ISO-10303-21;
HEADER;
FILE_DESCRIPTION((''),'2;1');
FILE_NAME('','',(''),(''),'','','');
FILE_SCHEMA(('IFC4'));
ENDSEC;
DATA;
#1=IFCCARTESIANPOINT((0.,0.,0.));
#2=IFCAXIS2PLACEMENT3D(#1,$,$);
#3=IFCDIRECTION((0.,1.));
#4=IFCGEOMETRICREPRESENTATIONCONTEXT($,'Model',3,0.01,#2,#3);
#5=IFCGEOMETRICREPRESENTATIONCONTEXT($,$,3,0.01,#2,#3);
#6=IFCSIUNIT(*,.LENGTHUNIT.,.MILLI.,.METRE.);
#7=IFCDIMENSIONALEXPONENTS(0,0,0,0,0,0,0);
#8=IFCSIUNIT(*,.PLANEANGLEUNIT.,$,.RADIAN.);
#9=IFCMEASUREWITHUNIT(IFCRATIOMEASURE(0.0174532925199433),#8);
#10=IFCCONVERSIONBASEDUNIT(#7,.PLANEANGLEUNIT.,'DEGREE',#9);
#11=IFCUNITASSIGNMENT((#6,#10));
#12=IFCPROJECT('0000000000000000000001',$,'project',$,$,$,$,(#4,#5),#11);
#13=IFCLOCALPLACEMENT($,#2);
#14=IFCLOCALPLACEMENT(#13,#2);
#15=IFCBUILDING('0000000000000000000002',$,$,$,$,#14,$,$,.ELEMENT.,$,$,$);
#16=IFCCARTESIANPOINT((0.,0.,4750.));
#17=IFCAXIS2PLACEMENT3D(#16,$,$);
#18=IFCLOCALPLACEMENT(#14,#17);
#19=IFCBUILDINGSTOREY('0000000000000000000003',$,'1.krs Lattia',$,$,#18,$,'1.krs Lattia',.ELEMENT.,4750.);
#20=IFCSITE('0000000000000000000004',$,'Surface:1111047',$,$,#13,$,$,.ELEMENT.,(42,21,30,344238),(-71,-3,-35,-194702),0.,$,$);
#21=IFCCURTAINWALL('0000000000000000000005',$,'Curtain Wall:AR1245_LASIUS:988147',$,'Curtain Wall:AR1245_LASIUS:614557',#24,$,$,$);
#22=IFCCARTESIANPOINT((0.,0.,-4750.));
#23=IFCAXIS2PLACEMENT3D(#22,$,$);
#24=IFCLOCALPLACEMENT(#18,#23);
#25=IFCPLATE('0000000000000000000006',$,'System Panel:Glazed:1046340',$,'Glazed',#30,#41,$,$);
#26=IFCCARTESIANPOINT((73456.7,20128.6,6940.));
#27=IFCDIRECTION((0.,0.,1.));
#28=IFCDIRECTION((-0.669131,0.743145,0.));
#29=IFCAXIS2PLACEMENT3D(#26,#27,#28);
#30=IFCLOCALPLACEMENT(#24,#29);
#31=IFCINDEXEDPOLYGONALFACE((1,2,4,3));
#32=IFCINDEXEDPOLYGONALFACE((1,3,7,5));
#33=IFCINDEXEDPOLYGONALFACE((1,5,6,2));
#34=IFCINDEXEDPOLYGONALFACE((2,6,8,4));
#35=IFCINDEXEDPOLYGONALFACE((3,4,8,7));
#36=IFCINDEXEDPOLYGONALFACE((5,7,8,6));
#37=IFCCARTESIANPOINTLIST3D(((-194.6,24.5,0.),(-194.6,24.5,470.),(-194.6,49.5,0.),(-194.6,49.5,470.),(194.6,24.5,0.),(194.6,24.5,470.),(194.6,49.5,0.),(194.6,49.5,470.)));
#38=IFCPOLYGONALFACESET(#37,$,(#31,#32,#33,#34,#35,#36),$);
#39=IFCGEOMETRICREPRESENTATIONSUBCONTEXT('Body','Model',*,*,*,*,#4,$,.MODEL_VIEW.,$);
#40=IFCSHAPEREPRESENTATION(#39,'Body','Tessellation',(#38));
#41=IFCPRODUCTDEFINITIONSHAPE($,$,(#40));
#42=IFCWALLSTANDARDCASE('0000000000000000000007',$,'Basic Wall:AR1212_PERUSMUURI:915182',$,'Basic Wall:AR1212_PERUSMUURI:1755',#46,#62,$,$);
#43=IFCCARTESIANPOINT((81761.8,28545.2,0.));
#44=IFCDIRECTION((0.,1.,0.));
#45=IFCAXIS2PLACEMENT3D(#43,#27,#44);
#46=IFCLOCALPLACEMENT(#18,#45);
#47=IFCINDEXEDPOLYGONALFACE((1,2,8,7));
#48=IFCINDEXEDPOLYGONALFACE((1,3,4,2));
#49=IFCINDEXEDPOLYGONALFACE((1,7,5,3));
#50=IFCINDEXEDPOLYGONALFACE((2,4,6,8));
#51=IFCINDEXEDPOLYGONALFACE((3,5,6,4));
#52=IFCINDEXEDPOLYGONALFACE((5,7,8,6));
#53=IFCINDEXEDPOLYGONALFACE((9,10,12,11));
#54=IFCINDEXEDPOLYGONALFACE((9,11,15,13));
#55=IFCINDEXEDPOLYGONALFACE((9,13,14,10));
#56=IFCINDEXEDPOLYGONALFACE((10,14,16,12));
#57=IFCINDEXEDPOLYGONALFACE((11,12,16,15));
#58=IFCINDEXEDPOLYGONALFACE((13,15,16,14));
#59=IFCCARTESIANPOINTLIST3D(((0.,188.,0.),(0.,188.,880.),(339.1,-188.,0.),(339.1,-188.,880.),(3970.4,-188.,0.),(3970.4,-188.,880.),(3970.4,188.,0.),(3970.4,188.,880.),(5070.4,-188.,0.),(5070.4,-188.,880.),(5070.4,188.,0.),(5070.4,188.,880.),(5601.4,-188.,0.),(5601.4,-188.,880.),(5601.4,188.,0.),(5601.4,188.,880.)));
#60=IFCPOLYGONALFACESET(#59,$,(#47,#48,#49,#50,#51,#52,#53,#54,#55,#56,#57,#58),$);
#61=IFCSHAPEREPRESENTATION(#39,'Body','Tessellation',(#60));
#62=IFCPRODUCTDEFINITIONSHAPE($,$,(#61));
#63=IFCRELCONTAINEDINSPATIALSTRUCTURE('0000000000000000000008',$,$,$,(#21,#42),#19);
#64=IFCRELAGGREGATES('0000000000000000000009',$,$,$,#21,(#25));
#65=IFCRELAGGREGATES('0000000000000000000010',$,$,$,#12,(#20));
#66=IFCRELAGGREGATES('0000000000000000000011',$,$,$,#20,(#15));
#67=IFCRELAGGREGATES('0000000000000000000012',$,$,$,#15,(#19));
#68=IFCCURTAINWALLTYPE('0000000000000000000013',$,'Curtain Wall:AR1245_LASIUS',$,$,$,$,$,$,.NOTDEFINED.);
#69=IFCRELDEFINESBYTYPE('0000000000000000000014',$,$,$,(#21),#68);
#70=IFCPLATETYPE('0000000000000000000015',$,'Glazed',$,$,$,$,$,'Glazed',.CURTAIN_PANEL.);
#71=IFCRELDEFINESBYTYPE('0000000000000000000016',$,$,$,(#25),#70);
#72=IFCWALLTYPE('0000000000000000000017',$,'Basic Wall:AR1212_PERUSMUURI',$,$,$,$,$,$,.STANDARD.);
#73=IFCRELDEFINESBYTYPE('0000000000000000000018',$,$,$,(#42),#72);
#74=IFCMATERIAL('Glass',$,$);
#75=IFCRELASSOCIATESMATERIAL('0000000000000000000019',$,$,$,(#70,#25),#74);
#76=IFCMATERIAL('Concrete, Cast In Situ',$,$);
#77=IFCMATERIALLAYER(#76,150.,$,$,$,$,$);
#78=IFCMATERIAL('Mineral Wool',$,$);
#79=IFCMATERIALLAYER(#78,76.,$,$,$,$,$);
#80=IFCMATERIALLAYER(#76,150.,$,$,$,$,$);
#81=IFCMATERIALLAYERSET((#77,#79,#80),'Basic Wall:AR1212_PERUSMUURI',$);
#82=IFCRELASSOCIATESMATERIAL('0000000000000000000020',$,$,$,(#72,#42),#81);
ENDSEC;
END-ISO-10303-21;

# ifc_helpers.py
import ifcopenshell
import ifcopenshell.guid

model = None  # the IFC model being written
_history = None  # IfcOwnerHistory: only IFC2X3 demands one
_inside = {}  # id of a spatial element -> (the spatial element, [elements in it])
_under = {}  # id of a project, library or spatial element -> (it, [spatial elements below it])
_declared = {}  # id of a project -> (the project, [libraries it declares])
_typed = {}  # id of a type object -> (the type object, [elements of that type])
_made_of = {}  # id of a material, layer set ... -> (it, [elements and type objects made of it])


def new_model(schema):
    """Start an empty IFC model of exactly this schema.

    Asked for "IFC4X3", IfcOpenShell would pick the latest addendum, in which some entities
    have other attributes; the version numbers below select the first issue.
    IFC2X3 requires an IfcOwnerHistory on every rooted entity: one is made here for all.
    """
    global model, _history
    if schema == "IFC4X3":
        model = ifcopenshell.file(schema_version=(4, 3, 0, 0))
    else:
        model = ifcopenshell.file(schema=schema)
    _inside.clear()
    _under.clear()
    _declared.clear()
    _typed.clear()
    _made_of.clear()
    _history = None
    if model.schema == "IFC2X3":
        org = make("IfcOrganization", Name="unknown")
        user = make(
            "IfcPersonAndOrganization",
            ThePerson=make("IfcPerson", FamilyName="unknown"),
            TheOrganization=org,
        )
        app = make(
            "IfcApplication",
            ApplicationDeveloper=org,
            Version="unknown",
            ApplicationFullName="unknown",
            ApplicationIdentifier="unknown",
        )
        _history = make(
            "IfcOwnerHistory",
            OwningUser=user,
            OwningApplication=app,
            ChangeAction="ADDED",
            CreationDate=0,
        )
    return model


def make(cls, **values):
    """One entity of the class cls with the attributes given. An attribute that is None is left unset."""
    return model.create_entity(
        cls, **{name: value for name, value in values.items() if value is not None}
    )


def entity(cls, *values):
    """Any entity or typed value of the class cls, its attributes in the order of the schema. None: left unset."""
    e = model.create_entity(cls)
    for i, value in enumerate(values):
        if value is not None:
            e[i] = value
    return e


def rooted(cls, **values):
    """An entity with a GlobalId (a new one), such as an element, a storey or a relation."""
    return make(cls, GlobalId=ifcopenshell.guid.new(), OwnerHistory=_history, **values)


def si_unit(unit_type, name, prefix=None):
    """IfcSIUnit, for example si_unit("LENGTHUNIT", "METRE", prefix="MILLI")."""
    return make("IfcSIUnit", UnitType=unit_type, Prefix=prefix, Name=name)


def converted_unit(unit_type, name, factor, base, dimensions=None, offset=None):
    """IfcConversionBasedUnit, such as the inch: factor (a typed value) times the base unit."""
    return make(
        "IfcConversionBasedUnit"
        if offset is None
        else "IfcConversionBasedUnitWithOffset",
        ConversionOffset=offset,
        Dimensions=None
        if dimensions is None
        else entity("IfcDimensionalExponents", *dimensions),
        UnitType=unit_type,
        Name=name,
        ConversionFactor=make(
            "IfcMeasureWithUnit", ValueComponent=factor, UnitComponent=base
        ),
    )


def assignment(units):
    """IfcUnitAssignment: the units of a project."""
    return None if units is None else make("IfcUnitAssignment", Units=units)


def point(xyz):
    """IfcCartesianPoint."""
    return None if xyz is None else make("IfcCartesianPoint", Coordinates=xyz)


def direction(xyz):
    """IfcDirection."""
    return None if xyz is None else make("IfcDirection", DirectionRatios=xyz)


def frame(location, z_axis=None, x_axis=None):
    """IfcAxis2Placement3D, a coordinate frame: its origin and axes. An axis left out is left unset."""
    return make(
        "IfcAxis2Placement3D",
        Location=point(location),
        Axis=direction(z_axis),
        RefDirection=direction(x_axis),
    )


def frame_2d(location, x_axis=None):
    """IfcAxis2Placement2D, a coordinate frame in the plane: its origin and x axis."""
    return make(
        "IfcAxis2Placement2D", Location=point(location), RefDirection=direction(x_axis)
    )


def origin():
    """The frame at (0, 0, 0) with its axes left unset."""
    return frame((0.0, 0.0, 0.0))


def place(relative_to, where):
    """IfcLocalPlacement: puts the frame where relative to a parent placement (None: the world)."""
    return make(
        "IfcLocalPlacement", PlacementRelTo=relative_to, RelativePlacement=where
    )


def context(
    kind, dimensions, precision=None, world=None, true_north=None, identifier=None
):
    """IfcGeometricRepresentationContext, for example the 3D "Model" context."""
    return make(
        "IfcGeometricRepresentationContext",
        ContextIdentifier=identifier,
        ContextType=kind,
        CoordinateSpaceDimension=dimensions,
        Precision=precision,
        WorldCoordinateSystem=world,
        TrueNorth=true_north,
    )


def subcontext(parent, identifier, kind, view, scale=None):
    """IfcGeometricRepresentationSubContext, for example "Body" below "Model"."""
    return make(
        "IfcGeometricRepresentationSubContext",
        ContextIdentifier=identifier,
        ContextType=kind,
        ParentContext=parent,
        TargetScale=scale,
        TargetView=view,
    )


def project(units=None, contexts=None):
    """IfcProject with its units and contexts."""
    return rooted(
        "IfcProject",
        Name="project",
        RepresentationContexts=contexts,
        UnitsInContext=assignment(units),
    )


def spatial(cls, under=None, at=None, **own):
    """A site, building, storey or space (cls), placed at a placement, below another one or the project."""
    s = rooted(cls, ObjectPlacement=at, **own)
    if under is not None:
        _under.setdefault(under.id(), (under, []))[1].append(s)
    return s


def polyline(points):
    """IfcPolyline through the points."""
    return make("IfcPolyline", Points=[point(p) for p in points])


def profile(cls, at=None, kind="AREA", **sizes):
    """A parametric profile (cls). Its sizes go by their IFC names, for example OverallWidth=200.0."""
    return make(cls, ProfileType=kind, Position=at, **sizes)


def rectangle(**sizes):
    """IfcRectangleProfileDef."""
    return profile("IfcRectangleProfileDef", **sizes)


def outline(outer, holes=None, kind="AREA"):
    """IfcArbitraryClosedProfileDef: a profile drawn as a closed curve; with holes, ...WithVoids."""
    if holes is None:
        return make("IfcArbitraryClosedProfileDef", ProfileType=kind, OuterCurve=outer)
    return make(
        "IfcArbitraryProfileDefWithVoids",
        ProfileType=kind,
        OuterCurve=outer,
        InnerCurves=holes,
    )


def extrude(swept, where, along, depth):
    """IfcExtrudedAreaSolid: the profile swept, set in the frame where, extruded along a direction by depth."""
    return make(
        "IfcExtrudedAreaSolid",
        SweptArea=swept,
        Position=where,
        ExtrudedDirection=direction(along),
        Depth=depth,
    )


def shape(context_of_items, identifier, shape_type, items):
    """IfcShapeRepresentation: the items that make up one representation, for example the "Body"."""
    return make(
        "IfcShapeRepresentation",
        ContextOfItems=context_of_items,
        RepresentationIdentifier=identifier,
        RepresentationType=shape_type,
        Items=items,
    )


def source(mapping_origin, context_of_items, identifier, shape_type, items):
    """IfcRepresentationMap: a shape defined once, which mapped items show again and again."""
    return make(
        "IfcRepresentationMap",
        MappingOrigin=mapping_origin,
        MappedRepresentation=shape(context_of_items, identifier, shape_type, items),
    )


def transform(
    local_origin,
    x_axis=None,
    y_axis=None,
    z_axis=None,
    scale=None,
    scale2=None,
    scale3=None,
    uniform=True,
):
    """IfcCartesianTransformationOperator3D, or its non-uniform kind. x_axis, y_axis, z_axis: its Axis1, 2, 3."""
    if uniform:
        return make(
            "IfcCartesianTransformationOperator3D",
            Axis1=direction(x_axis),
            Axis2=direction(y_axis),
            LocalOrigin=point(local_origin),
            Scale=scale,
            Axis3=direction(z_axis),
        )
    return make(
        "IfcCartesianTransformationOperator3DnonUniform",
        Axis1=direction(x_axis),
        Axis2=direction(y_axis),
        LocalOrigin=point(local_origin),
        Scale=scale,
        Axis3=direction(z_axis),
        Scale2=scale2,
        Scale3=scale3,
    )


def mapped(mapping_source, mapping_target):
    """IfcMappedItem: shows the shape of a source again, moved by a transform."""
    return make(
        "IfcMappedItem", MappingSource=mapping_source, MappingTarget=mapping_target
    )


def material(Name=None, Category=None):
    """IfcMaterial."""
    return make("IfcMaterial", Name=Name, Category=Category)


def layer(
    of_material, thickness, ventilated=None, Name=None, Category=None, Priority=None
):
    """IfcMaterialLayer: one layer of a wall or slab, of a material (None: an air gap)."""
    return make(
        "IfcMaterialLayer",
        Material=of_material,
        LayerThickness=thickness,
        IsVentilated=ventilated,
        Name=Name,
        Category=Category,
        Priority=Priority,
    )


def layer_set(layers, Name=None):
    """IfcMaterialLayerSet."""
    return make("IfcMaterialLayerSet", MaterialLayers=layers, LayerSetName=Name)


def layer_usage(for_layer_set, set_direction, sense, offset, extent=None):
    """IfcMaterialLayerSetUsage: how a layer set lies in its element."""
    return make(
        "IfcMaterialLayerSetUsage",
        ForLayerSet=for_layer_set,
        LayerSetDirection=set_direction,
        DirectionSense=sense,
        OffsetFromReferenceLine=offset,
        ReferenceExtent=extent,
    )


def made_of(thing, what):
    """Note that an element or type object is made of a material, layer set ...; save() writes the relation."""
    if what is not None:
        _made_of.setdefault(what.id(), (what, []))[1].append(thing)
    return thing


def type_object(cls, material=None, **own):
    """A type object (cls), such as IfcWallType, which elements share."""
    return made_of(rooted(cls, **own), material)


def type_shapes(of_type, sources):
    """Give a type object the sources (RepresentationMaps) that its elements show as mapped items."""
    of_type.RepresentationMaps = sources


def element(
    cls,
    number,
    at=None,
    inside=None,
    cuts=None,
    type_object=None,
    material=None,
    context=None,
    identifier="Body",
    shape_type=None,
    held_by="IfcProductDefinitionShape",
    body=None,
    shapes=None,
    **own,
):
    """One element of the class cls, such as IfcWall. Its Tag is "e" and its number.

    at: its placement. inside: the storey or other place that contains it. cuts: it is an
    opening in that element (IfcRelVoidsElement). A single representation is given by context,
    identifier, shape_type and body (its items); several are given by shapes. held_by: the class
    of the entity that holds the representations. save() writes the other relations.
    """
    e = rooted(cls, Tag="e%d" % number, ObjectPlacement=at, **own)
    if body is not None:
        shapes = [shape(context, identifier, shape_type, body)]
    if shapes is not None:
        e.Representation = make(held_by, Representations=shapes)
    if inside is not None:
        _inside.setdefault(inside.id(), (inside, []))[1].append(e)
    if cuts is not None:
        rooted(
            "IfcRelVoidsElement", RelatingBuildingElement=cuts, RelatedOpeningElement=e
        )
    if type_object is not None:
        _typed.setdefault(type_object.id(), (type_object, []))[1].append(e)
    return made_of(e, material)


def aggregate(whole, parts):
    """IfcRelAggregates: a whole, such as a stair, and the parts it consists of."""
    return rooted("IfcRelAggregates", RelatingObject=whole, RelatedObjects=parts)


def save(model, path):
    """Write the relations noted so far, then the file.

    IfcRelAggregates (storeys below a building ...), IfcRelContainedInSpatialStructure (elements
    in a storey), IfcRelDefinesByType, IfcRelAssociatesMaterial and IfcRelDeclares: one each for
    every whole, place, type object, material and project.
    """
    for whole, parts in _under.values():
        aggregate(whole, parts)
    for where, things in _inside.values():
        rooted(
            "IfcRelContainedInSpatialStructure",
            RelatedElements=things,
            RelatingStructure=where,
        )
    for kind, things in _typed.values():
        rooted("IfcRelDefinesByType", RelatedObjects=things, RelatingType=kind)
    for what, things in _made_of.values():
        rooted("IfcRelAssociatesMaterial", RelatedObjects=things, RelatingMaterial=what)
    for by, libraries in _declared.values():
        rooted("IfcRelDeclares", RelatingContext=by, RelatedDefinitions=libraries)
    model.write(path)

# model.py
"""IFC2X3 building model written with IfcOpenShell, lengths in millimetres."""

from ifc_helpers import new_model, entity, si_unit, converted_unit, direction, frame, frame_2d, origin, place, context, subcontext, project, spatial, polyline, rectangle, outline, extrude, source, transform, mapped, material, layer, layer_set, layer_usage, type_object, type_shapes, element, aggregate, save


model = new_model("IFC2X3")

# Units and contexts
model_context = context("Model", 3, precision=0.01, world=origin(), true_north=direction((0.0, 1.0)))
context_of_model = context(None, 3, precision=0.01, world=origin(), true_north=direction((0.0, 1.0)))
body_context = subcontext(model_context, "Body", "Model", "MODEL_VIEW")
ifc_project = project(units=[si_unit("LENGTHUNIT", "METRE", prefix="MILLI"), converted_unit("PLANEANGLEUNIT", "DEGREE", entity("IfcRatioMeasure", 0.0174532925199433), si_unit("PLANEANGLEUNIT", "RADIAN"), dimensions=[0, 0, 0, 0, 0, 0, 0])], contexts=[model_context, context_of_model])

# Site, building, storey
site_placement = place(None, origin())
site = spatial("IfcSite", under=ifc_project, at=site_placement, Name="Surface:1111047", CompositionType="ELEMENT", RefLatitude=(42, 21, 30, 344238), RefLongitude=(-71, -3, -35, -194702), RefElevation=0.0)
building_placement = place(site_placement, origin())
building = spatial("IfcBuilding", under=site, at=building_placement, CompositionType="ELEMENT")
storey_placement = place(building_placement, frame((0.0, 0.0, 4750.0)))
storey = spatial("IfcBuildingStorey", under=building, at=storey_placement, Name="1.krs Lattia", LongName="1.krs Lattia", CompositionType="ELEMENT", Elevation=4750.0)

# Curtain wall, plate
curtain_wall_type = type_object("IfcCurtainWallType", Name="Curtain Wall:AR1245_LASIUS", PredefinedType="NOTDEFINED")
ifc_material_1 = material(Name="Glass")
curtain_wall_1_placement = place(storey_placement, frame((0.0, 0.0, -4750.0)))
curtain_wall_1 = element("IfcCurtainWall", 1, at=curtain_wall_1_placement, inside=storey, type_object=curtain_wall_type, Name="Curtain Wall:AR1245_LASIUS:988147", ObjectType="Curtain Wall:AR1245_LASIUS:614557")
plate_type_1 = type_object("IfcPlateType", Name="Glazed", ElementType="Glazed", PredefinedType="CURTAIN_PANEL", material=ifc_material_1)
shared_shape_1 = source(origin(), body_context, "Body", "SweptSolid", [
    extrude(rectangle(XDim=25.0, YDim=389.3, at=frame_2d((0.0, 0.0), x_axis=(1.0, 0.0))), frame((0.0, 37.0, 0.0), z_axis=(0.0, 0.0, 1.0), x_axis=(0.0, 1.0, 0.0)), (0.0, 0.0, 1.0), 470.0),
])
type_shapes(plate_type_1, [shared_shape_1])
plate_1_placement = place(curtain_wall_1_placement, frame((73456.7, 20128.6, 6940.0), z_axis=(0.0, 0.0, 1.0), x_axis=(-0.669131, 0.743145, 0.0)))
plate_1 = element("IfcPlate", 2, at=plate_1_placement, type_object=plate_type_1, material=ifc_material_1, Name="System Panel:Glazed:1046340", ObjectType="Glazed", context=body_context, shape_type="MappedRepresentation", body=[
    mapped(shared_shape_1, transform((0.0, 0.0, 0.0), scale=1.0)),
])
aggregate(curtain_wall_1, [plate_1])

# Shared definitions
ifc_material_2 = material(Name="Concrete, Cast In Situ")
ifc_layer_1 = layer(ifc_material_2, 150.0)
ifc_material_3 = material(Name="Mineral Wool")
ifc_layer_2 = layer(ifc_material_3, 76.0)
ifc_layer_3 = layer(ifc_material_2, 150.0)
ifc_layer_set_1 = layer_set([ifc_layer_1, ifc_layer_2, ifc_layer_3], Name="Basic Wall:AR1212_PERUSMUURI")
wall_type_1 = type_object("IfcWallType", Name="Basic Wall:AR1212_PERUSMUURI", PredefinedType="STANDARD", material=ifc_layer_set_1)

# Wall, opening
ifc_layer_usage_1 = layer_usage(ifc_layer_set_1, "AXIS2", "NEGATIVE", 188.0)
wall_1_placement = place(storey_placement, frame((81761.8, 28545.2, 0.0), z_axis=(0.0, 0.0, 1.0), x_axis=(0.0, 1.0, 0.0)))
wall_1 = element("IfcWallStandardCase", 3, at=wall_1_placement, inside=storey, type_object=wall_type_1, material=ifc_layer_usage_1, Name="Basic Wall:AR1212_PERUSMUURI:915182", ObjectType="Basic Wall:AR1212_PERUSMUURI:1755", context=body_context, shape_type="SweptSolid", body=[
    extrude(outline(polyline([(339.1, -188.0), (5601.4, -188.0), (5601.4, 188.0), (0.0, 188.0), (339.1, -188.0)])), origin(), (0.0, 0.0, 1.0), 880.0),
])
opening_1_placement = place(wall_1_placement, origin())
element("IfcOpeningElement", 4, at=opening_1_placement, cuts=wall_1, ObjectType="Opening", context=body_context, shape_type="SweptSolid", body=[
    extrude(rectangle(XDim=2300.0, YDim=1100.0, at=frame_2d((0.0, 0.0), x_axis=(0.0, 1.0))), frame((4520.4, -1336.0, 1150.0), z_axis=(0.0, 1.0, 0.0), x_axis=(-1.0, 0.0, 0.0)), (0.0, 0.0, 1.0), 3048.0),
])

save(model, "model.ifc")
